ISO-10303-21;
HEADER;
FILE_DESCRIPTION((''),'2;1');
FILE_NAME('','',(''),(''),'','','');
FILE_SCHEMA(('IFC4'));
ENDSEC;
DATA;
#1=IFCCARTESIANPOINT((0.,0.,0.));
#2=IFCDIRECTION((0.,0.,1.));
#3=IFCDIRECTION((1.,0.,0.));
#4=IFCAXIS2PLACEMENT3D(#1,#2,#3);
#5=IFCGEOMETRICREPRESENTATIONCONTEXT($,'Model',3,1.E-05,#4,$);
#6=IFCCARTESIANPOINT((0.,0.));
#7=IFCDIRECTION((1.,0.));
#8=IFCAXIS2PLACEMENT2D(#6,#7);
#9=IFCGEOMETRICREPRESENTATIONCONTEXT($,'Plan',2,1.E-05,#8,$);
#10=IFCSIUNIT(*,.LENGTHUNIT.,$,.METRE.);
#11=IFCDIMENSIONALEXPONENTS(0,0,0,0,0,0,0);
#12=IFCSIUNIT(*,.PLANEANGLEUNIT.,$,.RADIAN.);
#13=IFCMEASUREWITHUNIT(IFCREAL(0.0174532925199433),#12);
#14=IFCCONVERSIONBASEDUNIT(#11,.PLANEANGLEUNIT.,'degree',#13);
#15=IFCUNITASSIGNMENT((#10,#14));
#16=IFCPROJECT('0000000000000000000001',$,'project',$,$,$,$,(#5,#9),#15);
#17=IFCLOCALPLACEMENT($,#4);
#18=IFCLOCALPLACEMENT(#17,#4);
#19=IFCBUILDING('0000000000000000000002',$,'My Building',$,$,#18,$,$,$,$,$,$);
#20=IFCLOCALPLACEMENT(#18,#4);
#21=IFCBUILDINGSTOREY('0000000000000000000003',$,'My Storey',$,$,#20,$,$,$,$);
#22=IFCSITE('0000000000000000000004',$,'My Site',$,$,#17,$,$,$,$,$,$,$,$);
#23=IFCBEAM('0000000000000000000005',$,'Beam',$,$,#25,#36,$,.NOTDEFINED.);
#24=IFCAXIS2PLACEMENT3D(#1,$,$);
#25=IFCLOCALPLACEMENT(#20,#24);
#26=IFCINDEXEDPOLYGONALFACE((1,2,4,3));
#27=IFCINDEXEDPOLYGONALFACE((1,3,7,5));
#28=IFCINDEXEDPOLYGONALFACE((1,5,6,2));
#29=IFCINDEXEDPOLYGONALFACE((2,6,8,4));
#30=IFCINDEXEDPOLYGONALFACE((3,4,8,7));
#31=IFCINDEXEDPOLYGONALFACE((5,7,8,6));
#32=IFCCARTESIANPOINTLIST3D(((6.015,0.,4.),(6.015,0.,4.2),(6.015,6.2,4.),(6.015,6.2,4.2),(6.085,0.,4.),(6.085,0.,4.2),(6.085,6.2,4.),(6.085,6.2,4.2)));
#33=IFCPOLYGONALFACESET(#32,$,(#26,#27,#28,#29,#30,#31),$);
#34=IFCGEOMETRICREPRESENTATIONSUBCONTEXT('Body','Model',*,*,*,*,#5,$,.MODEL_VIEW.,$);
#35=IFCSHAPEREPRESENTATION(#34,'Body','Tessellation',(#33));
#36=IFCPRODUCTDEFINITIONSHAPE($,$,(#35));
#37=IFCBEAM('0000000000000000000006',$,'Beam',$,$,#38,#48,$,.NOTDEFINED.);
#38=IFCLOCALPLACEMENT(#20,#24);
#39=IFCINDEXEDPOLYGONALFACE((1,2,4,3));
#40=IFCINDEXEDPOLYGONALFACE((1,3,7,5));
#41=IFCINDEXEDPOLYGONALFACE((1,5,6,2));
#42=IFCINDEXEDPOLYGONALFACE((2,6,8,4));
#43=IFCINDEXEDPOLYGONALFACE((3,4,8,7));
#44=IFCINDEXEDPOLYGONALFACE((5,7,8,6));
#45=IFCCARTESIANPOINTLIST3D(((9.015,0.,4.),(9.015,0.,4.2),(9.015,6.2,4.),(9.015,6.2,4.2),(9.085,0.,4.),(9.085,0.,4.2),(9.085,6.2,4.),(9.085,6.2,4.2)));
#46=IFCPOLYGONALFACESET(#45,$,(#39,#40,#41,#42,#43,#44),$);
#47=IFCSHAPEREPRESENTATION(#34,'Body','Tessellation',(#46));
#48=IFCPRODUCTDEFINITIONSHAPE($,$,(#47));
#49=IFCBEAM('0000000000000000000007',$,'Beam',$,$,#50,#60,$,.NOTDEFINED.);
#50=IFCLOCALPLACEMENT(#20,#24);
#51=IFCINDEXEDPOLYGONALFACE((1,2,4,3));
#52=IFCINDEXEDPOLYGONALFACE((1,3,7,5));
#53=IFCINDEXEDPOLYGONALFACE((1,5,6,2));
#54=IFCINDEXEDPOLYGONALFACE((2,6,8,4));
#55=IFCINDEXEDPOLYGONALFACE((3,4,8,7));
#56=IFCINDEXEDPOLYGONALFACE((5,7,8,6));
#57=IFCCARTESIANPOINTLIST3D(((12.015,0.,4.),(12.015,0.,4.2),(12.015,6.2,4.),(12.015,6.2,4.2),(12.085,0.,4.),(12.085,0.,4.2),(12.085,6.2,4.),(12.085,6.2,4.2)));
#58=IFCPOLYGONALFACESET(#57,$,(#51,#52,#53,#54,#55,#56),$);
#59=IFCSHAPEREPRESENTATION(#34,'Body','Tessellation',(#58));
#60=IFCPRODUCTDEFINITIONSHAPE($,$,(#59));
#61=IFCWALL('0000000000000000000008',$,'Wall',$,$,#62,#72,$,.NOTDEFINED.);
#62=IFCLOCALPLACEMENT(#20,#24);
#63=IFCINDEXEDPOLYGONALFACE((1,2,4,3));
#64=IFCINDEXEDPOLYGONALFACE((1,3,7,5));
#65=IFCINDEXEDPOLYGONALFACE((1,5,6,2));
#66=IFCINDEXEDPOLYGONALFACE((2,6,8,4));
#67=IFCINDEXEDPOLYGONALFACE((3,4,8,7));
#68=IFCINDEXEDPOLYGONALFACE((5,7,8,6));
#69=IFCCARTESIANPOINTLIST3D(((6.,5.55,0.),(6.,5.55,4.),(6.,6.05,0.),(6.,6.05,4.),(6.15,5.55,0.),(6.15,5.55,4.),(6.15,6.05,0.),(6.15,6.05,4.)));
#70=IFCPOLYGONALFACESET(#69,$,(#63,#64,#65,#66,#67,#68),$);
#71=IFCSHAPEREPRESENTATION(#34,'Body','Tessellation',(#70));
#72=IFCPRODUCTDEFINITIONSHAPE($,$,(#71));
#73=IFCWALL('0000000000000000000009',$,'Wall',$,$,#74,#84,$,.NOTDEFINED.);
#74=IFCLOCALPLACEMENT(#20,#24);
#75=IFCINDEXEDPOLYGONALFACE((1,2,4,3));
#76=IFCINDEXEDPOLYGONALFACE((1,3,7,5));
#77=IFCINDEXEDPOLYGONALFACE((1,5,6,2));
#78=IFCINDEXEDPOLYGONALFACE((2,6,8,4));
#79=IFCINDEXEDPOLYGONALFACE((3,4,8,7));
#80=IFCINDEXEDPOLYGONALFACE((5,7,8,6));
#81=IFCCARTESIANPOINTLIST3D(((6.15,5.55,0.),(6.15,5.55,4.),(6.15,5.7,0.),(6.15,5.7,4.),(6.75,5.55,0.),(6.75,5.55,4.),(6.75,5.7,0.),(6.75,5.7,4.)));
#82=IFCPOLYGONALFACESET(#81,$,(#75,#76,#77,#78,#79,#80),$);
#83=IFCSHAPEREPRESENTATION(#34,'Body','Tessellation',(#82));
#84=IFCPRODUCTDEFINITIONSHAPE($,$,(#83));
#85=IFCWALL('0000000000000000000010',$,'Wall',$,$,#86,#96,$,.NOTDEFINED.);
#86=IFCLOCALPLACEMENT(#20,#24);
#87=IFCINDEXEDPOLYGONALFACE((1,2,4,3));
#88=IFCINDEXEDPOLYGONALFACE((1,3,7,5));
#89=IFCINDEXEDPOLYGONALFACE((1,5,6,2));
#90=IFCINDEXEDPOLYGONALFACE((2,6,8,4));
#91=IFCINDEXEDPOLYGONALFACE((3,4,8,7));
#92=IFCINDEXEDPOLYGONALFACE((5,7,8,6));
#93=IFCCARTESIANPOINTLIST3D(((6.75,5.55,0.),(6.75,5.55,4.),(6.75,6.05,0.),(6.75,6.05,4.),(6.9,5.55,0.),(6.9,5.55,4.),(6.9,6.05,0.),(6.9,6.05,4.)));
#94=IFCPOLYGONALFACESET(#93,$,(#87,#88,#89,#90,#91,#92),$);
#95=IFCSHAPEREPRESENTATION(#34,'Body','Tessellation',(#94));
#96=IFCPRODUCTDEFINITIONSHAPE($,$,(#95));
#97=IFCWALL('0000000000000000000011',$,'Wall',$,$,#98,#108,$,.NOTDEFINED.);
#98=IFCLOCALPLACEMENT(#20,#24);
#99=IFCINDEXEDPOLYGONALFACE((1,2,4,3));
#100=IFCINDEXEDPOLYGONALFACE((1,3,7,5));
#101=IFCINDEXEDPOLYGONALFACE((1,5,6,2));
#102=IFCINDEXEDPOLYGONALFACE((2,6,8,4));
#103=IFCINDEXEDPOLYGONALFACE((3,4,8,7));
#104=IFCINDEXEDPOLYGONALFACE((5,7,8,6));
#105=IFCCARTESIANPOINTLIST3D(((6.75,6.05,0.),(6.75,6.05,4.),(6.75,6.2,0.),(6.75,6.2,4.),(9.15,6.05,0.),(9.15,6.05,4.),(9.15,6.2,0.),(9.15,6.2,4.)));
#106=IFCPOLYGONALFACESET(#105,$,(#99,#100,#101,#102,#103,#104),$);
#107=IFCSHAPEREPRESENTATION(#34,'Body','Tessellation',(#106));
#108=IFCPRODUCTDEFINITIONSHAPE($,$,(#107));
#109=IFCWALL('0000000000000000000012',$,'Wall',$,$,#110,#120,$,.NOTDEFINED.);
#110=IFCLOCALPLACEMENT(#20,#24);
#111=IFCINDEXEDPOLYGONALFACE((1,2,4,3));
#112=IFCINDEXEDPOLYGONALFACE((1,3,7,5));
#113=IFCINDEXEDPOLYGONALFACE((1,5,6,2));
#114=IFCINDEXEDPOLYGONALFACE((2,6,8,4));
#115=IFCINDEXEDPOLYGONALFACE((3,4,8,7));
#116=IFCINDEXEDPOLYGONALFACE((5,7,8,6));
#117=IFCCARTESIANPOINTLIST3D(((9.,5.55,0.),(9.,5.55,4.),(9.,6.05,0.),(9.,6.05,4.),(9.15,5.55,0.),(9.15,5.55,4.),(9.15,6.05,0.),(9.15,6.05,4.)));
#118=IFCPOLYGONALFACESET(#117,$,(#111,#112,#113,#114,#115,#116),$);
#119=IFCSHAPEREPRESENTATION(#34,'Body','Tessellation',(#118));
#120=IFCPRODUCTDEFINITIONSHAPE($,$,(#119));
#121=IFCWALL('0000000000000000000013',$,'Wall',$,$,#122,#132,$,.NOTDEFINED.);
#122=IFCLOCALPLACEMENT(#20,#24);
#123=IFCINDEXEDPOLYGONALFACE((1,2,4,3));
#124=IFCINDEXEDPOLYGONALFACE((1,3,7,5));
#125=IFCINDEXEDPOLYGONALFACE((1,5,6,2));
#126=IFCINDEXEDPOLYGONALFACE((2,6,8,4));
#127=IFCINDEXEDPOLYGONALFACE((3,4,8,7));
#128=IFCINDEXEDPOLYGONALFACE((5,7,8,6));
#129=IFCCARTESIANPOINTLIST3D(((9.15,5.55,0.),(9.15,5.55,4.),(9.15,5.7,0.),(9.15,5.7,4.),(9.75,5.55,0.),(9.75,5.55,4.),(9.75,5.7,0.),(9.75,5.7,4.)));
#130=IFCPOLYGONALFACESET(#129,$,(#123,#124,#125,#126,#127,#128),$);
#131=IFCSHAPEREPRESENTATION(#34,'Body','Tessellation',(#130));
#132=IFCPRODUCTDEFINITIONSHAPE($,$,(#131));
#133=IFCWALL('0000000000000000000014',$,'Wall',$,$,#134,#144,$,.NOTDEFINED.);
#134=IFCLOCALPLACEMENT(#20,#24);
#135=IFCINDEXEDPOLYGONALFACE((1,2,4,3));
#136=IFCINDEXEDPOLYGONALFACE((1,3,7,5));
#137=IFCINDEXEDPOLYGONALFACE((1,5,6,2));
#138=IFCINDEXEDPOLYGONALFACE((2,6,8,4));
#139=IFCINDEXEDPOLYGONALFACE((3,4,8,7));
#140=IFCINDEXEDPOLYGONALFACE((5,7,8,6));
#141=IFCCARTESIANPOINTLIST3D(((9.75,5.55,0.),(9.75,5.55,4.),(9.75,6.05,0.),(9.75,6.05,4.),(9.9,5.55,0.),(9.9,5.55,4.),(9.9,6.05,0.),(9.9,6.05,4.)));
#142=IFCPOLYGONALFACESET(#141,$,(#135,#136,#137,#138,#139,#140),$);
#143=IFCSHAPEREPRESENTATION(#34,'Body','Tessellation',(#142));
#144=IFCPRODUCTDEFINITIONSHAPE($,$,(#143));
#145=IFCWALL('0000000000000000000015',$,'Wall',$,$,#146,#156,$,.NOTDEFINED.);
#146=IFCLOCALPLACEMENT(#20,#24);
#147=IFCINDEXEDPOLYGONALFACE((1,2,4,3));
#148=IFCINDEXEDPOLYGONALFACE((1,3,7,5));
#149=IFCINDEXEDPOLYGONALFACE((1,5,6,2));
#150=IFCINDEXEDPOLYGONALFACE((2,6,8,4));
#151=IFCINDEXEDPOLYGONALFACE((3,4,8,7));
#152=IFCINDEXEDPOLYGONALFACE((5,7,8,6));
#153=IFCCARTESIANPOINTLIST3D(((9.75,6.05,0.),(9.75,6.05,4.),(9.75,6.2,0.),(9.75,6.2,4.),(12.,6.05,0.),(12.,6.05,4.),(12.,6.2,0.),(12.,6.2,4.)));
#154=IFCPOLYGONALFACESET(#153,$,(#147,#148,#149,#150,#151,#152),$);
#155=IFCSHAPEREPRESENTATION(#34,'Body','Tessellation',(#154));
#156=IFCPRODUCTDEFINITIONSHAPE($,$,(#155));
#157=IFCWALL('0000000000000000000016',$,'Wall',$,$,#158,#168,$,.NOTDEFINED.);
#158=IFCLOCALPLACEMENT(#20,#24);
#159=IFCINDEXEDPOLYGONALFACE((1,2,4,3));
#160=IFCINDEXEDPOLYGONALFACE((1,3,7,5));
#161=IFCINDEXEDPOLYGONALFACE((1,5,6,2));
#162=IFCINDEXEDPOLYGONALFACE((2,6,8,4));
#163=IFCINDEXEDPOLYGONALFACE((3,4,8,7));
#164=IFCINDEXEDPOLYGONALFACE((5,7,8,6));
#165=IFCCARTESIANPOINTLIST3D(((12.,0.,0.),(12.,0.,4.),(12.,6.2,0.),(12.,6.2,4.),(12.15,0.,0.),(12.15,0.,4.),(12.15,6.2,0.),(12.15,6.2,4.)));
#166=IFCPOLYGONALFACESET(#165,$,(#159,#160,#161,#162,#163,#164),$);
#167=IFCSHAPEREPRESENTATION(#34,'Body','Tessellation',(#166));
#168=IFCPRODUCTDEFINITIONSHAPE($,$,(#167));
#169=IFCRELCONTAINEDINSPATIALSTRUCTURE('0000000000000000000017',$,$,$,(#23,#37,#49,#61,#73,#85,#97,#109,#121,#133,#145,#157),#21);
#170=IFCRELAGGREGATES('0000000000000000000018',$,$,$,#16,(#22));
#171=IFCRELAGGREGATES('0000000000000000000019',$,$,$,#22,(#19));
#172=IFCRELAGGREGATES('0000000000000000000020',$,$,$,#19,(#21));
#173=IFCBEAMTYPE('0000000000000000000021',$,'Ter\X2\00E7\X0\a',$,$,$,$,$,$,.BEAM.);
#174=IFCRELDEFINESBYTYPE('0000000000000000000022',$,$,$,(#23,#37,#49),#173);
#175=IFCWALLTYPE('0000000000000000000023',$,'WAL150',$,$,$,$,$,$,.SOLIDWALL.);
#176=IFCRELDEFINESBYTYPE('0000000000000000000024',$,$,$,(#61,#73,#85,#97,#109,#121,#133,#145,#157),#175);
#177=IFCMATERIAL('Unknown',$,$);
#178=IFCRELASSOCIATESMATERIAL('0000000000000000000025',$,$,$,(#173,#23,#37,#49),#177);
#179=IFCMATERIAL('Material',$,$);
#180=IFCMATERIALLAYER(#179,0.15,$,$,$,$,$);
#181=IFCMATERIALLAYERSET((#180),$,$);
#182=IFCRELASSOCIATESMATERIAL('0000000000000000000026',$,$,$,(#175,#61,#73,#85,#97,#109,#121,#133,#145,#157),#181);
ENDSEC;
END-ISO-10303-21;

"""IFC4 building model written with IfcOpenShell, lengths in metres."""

from ifc_helpers import new_model, entity, si_unit, converted_unit, frame, origin_with_axes, origin_2d_with_axis, place, context, subcontext, project, spatial, indexed_curve, rectangle, outline, extrude, material, layer, layer_set, layer_usage, material_profile, profile_set, profile_usage, type_object, element, save


model = new_model("IFC4")

# Units and contexts
model_context = context("Model", 3, precision=1e-05, world=origin_with_axes())
plan_context = context("Plan", 2, precision=1e-05, world=origin_2d_with_axis())
body_context = subcontext(model_context, "Body", "Model", "MODEL_VIEW")
ifc_project = project(units=[si_unit("LENGTHUNIT", "METRE"), converted_unit("PLANEANGLEUNIT", "degree", entity("IfcReal", 0.0174532925199433), si_unit("PLANEANGLEUNIT", "RADIAN"), dimensions=[0, 0, 0, 0, 0, 0, 0])], contexts=[model_context, plan_context])

# Site, building, storey
site_placement = place(None, origin_with_axes())
site = spatial("IfcSite", under=ifc_project, at=site_placement, Name="My Site")
building_placement = place(site_placement, origin_with_axes())
building = spatial("IfcBuilding", under=site, at=building_placement, Name="My Building")
storey_placement = place(building_placement, origin_with_axes())
storey = spatial("IfcBuildingStorey", under=building, at=storey_placement, Name="My Storey")

# Shared definitions
ifc_material_1 = material(Name="Unknown")

# Beams
ifc_material_profile_1 = material_profile(ifc_material_1, rectangle(XDim=0.07, YDim=0.2))
ifc_profile_set_1 = profile_set([ifc_material_profile_1])
ifc_profile_usage_1 = profile_usage(ifc_profile_set_1, cardinal=2)
beam_type = type_object("IfcBeamType", Name="Terça", PredefinedType="BEAM", material=ifc_profile_set_1)
beam_1_placement = place(storey_placement, frame((6.05, 6.2, 4.0), z_axis=(0.0, -1.0, 0.0), x_axis=(1.0, 0.0, 0.0)))
element("IfcBeam", 1, at=beam_1_placement, inside=storey, type_object=beam_type, material=ifc_profile_usage_1, Name="Beam", PredefinedType="NOTDEFINED", context=body_context, shape_type="SweptSolid", body=[
    extrude(rectangle(XDim=0.07, YDim=0.2), frame((0.0, 0.1, 0.0), z_axis=(0.0, 0.0, 1.0), x_axis=(1.0, 0.0, 0.0)), (0.0, 0.0, 1.0), 6.2),
])
ifc_profile_usage_2 = profile_usage(ifc_profile_set_1, cardinal=2)
beam_2_placement = place(storey_placement, frame((9.05, 6.2, 4.0), z_axis=(0.0, -1.0, 0.0), x_axis=(1.0, 0.0, 0.0)))
element("IfcBeam", 2, at=beam_2_placement, inside=storey, type_object=beam_type, material=ifc_profile_usage_2, Name="Beam", PredefinedType="NOTDEFINED", context=body_context, shape_type="SweptSolid", body=[
    extrude(rectangle(XDim=0.07, YDim=0.2), frame((0.0, 0.1, 0.0), z_axis=(0.0, 0.0, 1.0), x_axis=(1.0, 0.0, 0.0)), (0.0, 0.0, 1.0), 6.2),
])
ifc_profile_usage_3 = profile_usage(ifc_profile_set_1, cardinal=2)
beam_3_placement = place(storey_placement, frame((12.05, 6.2, 4.0), z_axis=(0.0, -1.0, 0.0), x_axis=(1.0, 0.0, 0.0)))
element("IfcBeam", 3, at=beam_3_placement, inside=storey, type_object=beam_type, material=ifc_profile_usage_3, Name="Beam", PredefinedType="NOTDEFINED", context=body_context, shape_type="SweptSolid", body=[
    extrude(rectangle(XDim=0.07, YDim=0.2), frame((0.0, 0.1, 0.0), z_axis=(0.0, 0.0, 1.0), x_axis=(1.0, 0.0, 0.0)), (0.0, 0.0, 1.0), 6.2),
])

# Walls
ifc_material_2 = material(Name="Material")
ifc_layer = layer(ifc_material_2, 0.15)
ifc_layer_set = layer_set([ifc_layer])
ifc_layer_usage_1 = layer_usage(ifc_layer_set, "AXIS2", "POSITIVE", 0.0)
wall_type = type_object("IfcWallType", Name="WAL150", PredefinedType="SOLIDWALL", material=ifc_layer_set)
wall_1_placement = place(storey_placement, frame((6.0, 6.05, 0.0), z_axis=(0.0, 0.0, 1.0), x_axis=(-0.000001, -1.0, 0.0)))
element("IfcWall", 4, at=wall_1_placement, inside=storey, type_object=wall_type, material=ifc_layer_usage_1, Name="Wall", PredefinedType="NOTDEFINED", context=body_context, shape_type="SweptSolid", body=[
    extrude(outline(indexed_curve([(0.0, 0.0), (0.0, 0.15), (0.5, 0.15), (0.5, 0.0), (0.0, 0.0)], self_intersect=False)), origin_with_axes(), (0.0, 0.0, 1.0), 4.0),
])
ifc_layer_usage_2 = layer_usage(ifc_layer_set, "AXIS2", "POSITIVE", 0.0)
wall_2_placement = place(storey_placement, frame((6.15, 5.55, 0.0), z_axis=(0.0, 0.0, 1.0), x_axis=(1.0, -0.000001, 0.0)))
element("IfcWall", 5, at=wall_2_placement, inside=storey, type_object=wall_type, material=ifc_layer_usage_2, Name="Wall", PredefinedType="NOTDEFINED", context=body_context, shape_type="SweptSolid", body=[
    extrude(outline(indexed_curve([(0.0, 0.0), (0.0, 0.15), (0.6, 0.15), (0.6, 0.0), (0.0, 0.0)], self_intersect=False)), origin_with_axes(), (0.0, 0.0, 1.0), 4.0),
])
ifc_layer_usage_3 = layer_usage(ifc_layer_set, "AXIS2", "POSITIVE", 0.0)
wall_3_placement = place(storey_placement, frame((6.75, 6.05, 0.0), z_axis=(0.0, 0.0, 1.0), x_axis=(-0.000001, -1.0, 0.0)))
element("IfcWall", 6, at=wall_3_placement, inside=storey, type_object=wall_type, material=ifc_layer_usage_3, Name="Wall", PredefinedType="NOTDEFINED", context=body_context, shape_type="SweptSolid", body=[
    extrude(outline(indexed_curve([(0.0, 0.0), (0.0, 0.15), (0.5, 0.15), (0.5, 0.0), (0.0, 0.0)], self_intersect=False)), origin_with_axes(), (0.0, 0.0, 1.0), 4.0),
])
ifc_layer_usage_4 = layer_usage(ifc_layer_set, "AXIS2", "POSITIVE", 0.0)
wall_4_placement = place(storey_placement, frame((6.75, 6.05, 0.0), z_axis=(0.0, 0.0, 1.0), x_axis=(1.0, -0.000001, 0.0)))
element("IfcWall", 7, at=wall_4_placement, inside=storey, type_object=wall_type, material=ifc_layer_usage_4, Name="Wall", PredefinedType="NOTDEFINED", context=body_context, shape_type="SweptSolid", body=[
    extrude(outline(indexed_curve([(0.0, 0.0), (0.0, 0.15), (2.4, 0.15), (2.4, 0.0), (0.0, 0.0)], self_intersect=False)), origin_with_axes(), (0.0, 0.0, 1.0), 4.0),
])
ifc_layer_usage_5 = layer_usage(ifc_layer_set, "AXIS2", "POSITIVE", 0.0)
wall_5_placement = place(storey_placement, frame((9.0, 6.05, 0.0), z_axis=(0.0, 0.0, 1.0), x_axis=(-0.000001, -1.0, 0.0)))
element("IfcWall", 8, at=wall_5_placement, inside=storey, type_object=wall_type, material=ifc_layer_usage_5, Name="Wall", PredefinedType="NOTDEFINED", context=body_context, shape_type="SweptSolid", body=[
    extrude(outline(indexed_curve([(0.0, 0.0), (0.0, 0.15), (0.5, 0.15), (0.5, 0.0), (0.0, 0.0)], self_intersect=False)), origin_with_axes(), (0.0, 0.0, 1.0), 4.0),
])
ifc_layer_usage_6 = layer_usage(ifc_layer_set, "AXIS2", "POSITIVE", 0.0)
wall_6_placement = place(storey_placement, frame((9.15, 5.55, 0.0), z_axis=(0.0, 0.0, 1.0), x_axis=(1.0, -0.000001, 0.0)))
element("IfcWall", 9, at=wall_6_placement, inside=storey, type_object=wall_type, material=ifc_layer_usage_6, Name="Wall", PredefinedType="NOTDEFINED", context=body_context, shape_type="SweptSolid", body=[
    extrude(outline(indexed_curve([(0.0, 0.0), (0.0, 0.15), (0.6, 0.15), (0.6, 0.0), (0.0, 0.0)], self_intersect=False)), origin_with_axes(), (0.0, 0.0, 1.0), 4.0),
])
ifc_layer_usage_7 = layer_usage(ifc_layer_set, "AXIS2", "POSITIVE", 0.0)
wall_7_placement = place(storey_placement, frame((9.75, 6.05, 0.0), z_axis=(0.0, 0.0, 1.0), x_axis=(-0.000001, -1.0, 0.0)))
element("IfcWall", 10, at=wall_7_placement, inside=storey, type_object=wall_type, material=ifc_layer_usage_7, Name="Wall", PredefinedType="NOTDEFINED", context=body_context, shape_type="SweptSolid", body=[
    extrude(outline(indexed_curve([(0.0, 0.0), (0.0, 0.15), (0.5, 0.15), (0.5, 0.0), (0.0, 0.0)], self_intersect=False)), origin_with_axes(), (0.0, 0.0, 1.0), 4.0),
])
ifc_layer_usage_8 = layer_usage(ifc_layer_set, "AXIS2", "POSITIVE", 0.0)
wall_8_placement = place(storey_placement, frame((9.75, 6.05, 0.0), z_axis=(0.0, 0.0, 1.0), x_axis=(1.0, -0.000001, 0.0)))
element("IfcWall", 11, at=wall_8_placement, inside=storey, type_object=wall_type, material=ifc_layer_usage_8, Name="Wall", PredefinedType="NOTDEFINED", context=body_context, shape_type="SweptSolid", body=[
    extrude(outline(indexed_curve([(0.0, 0.0), (0.0, 0.15), (2.25, 0.15), (2.25, 0.0), (0.0, 0.0)], self_intersect=False)), origin_with_axes(), (0.0, 0.0, 1.0), 4.0),
])
ifc_layer_usage_9 = layer_usage(ifc_layer_set, "AXIS2", "POSITIVE", 0.0)
wall_9_placement = place(storey_placement, frame((12.0, 6.2, 0.0), z_axis=(0.0, 0.0, 1.0), x_axis=(0.0, -1.0, 0.0)))
element("IfcWall", 12, at=wall_9_placement, inside=storey, type_object=wall_type, material=ifc_layer_usage_9, Name="Wall", PredefinedType="NOTDEFINED", context=body_context, shape_type="SweptSolid", body=[
    extrude(outline(indexed_curve([(0.0, 0.0), (0.0, 0.15), (6.2, 0.15), (6.2, 0.0), (0.0, 0.0)], self_intersect=False)), origin_with_axes(), (0.0, 0.0, 1.0), 4.0),
])

save(model, "model.ifc")
